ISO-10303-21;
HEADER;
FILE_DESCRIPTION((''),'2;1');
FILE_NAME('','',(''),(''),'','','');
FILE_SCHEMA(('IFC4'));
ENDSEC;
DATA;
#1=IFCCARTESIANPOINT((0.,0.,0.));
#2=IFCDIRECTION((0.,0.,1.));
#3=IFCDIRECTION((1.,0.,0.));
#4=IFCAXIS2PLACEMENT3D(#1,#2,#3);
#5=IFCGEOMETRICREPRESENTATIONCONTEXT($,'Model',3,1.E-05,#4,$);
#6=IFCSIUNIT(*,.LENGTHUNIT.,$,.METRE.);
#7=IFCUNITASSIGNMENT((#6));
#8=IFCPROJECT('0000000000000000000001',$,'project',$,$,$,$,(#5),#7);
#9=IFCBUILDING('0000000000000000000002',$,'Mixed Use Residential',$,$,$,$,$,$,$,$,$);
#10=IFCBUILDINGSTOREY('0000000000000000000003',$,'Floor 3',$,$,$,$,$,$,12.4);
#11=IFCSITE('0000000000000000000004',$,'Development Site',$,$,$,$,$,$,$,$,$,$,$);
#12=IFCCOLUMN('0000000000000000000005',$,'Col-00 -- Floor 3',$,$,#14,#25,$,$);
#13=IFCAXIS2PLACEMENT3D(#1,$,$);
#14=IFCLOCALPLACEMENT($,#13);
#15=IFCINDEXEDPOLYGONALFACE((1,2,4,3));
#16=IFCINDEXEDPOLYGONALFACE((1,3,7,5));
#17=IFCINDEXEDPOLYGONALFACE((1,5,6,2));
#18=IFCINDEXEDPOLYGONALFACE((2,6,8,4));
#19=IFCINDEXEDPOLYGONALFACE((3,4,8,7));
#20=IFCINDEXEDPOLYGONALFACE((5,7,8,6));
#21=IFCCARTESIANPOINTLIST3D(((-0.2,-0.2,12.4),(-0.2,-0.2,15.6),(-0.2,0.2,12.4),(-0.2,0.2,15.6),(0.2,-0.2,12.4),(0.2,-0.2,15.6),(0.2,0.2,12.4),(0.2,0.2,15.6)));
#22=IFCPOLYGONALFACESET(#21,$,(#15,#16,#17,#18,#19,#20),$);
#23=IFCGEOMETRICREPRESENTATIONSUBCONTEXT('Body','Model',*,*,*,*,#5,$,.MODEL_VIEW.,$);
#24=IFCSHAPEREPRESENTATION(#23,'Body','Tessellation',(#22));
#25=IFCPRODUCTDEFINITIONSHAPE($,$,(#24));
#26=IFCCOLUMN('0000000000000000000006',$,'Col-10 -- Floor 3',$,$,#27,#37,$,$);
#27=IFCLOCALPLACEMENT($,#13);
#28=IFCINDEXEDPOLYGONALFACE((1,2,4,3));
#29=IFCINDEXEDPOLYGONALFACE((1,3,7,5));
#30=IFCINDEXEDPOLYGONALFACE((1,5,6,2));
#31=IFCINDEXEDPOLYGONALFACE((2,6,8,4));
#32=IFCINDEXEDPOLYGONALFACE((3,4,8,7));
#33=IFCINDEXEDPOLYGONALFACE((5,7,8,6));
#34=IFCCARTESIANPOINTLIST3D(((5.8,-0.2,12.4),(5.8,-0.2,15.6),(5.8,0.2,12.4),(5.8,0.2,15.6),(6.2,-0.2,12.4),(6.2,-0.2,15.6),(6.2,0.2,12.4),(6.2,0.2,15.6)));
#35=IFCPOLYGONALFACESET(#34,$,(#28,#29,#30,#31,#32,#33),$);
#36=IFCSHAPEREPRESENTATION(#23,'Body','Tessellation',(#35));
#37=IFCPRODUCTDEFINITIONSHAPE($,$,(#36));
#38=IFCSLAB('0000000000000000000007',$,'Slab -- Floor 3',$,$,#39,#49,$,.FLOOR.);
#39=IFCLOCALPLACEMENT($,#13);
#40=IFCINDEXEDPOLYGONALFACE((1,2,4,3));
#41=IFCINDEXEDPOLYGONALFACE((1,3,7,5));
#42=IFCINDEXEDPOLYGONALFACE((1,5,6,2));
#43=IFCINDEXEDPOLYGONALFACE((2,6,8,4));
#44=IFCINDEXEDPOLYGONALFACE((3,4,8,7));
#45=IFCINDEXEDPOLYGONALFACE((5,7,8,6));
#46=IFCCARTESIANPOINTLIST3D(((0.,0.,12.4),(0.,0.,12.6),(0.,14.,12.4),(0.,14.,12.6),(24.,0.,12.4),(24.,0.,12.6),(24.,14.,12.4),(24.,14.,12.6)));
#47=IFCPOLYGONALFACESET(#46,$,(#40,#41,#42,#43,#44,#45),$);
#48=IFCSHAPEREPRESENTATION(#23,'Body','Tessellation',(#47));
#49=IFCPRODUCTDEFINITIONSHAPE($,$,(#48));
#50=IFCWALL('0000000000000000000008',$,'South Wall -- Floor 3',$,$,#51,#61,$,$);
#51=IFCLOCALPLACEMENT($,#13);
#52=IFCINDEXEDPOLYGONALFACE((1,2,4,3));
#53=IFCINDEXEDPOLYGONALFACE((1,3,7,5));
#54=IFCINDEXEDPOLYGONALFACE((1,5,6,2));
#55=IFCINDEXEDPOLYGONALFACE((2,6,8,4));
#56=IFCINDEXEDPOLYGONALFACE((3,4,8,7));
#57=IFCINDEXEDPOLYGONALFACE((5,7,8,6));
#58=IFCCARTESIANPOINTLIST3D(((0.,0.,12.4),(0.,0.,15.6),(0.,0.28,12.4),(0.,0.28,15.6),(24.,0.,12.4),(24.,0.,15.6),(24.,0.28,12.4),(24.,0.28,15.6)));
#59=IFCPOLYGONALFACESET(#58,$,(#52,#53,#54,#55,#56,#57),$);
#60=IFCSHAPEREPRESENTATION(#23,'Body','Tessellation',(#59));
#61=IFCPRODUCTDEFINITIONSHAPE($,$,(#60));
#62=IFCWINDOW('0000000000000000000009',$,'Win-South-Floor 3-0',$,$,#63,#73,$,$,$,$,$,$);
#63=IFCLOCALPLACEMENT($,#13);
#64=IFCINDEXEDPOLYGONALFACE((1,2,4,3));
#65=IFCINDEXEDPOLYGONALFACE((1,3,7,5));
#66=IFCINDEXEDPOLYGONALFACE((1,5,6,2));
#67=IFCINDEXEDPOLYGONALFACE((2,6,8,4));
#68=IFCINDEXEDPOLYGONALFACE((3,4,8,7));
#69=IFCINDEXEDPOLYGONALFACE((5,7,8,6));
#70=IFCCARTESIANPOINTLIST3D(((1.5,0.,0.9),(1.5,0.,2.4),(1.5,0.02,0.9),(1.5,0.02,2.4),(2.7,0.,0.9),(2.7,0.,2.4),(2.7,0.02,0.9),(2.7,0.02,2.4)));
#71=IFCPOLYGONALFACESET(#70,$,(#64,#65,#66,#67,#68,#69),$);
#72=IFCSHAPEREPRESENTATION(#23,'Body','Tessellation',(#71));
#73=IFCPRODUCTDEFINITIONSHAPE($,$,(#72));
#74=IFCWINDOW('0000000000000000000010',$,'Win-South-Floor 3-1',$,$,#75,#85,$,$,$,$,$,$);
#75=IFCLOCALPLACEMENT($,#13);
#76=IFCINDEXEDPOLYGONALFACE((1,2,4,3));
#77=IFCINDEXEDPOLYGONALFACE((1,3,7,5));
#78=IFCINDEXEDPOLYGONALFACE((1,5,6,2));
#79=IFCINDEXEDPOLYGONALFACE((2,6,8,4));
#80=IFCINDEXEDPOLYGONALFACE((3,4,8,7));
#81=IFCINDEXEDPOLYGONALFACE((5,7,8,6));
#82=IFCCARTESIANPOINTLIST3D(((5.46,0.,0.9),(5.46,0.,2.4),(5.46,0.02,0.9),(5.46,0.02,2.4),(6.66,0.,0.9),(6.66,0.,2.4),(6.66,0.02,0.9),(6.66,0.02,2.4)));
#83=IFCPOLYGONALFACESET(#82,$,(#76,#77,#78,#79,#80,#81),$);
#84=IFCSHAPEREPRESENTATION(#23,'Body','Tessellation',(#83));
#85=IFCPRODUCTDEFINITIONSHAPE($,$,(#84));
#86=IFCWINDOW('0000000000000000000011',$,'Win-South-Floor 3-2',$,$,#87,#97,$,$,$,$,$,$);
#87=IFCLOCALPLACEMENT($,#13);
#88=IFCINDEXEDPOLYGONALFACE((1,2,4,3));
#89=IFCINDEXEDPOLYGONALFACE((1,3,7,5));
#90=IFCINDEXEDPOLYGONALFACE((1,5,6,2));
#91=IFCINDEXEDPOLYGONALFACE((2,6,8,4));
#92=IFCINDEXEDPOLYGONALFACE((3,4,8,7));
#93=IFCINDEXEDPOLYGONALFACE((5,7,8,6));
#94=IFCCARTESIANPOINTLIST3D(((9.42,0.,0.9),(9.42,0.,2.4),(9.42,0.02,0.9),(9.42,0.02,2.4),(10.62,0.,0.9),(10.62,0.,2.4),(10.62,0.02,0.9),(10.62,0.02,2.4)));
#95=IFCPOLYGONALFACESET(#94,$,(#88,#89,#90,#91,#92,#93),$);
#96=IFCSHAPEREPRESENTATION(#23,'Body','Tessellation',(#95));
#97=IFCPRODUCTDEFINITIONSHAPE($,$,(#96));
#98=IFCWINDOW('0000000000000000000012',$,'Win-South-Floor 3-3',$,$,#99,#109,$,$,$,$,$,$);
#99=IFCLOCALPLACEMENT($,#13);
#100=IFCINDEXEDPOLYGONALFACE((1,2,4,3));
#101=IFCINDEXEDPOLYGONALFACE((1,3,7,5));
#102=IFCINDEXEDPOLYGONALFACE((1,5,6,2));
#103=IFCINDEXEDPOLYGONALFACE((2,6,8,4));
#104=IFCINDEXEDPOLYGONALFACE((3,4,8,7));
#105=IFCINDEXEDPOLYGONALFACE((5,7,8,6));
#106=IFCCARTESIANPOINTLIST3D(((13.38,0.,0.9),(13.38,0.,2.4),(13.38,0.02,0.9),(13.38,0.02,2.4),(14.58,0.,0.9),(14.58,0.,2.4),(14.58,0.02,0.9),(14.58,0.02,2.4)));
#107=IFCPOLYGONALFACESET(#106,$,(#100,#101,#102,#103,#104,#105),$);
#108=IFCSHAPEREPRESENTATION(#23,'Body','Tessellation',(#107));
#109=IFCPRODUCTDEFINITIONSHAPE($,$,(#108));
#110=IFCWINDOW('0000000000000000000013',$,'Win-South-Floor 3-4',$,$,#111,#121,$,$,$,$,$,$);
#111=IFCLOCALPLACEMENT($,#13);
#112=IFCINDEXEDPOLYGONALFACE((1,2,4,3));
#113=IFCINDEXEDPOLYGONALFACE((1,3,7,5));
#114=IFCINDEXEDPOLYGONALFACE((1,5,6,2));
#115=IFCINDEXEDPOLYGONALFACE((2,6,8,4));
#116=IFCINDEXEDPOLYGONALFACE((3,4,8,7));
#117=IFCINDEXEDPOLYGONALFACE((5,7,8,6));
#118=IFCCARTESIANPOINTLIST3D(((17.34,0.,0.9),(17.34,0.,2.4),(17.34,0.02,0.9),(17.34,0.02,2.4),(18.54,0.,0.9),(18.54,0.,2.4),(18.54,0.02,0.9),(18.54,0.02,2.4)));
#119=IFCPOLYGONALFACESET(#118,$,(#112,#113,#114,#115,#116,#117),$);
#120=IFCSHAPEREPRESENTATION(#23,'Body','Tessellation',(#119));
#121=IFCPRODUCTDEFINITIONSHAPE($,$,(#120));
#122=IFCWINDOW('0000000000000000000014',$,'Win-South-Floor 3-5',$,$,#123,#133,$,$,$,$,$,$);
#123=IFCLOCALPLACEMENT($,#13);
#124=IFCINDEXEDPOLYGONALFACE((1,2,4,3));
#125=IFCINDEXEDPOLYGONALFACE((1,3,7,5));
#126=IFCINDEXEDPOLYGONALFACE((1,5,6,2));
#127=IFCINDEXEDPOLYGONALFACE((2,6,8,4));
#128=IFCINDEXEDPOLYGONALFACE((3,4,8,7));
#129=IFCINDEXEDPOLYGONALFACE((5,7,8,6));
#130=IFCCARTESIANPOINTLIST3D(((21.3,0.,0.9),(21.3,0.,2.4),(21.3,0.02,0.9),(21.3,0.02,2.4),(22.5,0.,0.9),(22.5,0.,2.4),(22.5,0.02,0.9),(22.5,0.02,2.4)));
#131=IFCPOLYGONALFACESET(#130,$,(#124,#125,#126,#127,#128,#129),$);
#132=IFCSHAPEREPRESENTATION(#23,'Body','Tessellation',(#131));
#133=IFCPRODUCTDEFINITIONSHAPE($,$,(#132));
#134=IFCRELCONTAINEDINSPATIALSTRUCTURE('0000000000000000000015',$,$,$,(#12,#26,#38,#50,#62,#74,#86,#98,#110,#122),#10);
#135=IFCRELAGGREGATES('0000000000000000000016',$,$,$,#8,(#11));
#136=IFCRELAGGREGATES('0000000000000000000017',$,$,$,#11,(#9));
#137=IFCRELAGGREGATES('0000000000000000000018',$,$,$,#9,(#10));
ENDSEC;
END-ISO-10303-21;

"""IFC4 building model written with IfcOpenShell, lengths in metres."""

from ifc_helpers import new_model, si_unit, frame, origin_with_axes, place, context, subcontext, project, spatial, indexed_curve, rectangle, outline, extrude, element, fill, save


model = new_model("IFC4")

# Units and contexts
model_context = context("Model", 3, precision=1e-05, world=origin_with_axes())
body_context = subcontext(model_context, "Body", "Model", "MODEL_VIEW")
ifc_project = project(units=[si_unit("LENGTHUNIT", "METRE")], contexts=[model_context])

# Site, building, storey
site = spatial("IfcSite", under=ifc_project, Name="Development Site")
building = spatial("IfcBuilding", under=site, Name="Mixed Use Residential")
storey = spatial("IfcBuildingStorey", under=building, Name="Floor 3", Elevation=12.4)

# Columns
for number, where, z_axis, x_axis, name in (
    (1, (0.0, 0.0, 12.4), (0.0, 0.0, 1.0), (1.0, 0.0, 0.0), "Col-00 -- Floor 3"),
    (2, (6.0, 0.0, 12.4), (0.0, 0.0, 1.0), (1.0, 0.0, 0.0), "Col-10 -- Floor 3"),
):
    element("IfcColumn", number, at=place(None, frame(where, z_axis=z_axis, x_axis=x_axis)), inside=storey, Name=name, context=body_context, shape_type="SweptSolid", body=[
        extrude(rectangle(XDim=0.4, YDim=0.4), origin_with_axes(), (0.0, 0.0, 1.0), 3.2),
    ])

# Slab
slab_placement = place(None, frame((0.0, 0.0, 12.4), z_axis=(0.0, 0.0, 1.0), x_axis=(1.0, 0.0, 0.0)))
element("IfcSlab", 3, at=slab_placement, inside=storey, Name="Slab -- Floor 3", PredefinedType="FLOOR", context=body_context, shape_type="SweptSolid", body=[
    extrude(outline(indexed_curve([(0.0, 0.0), (24.0, 0.0), (24.0, 14.0), (0.0, 14.0), (0.0, 0.0)])), None, (0.0, 0.0, 1.0), 0.2),
])

# Wall, openings, windows
wall_1_placement = place(None, frame((0.0, 0.0, 12.4), z_axis=(0.0, 0.0, 1.0), x_axis=(1.0, 0.0, 0.0)))
wall_1 = element("IfcWall", 4, at=wall_1_placement, inside=storey, Name="South Wall -- Floor 3", context=body_context, shape_type="SweptSolid", body=[
    extrude(outline(indexed_curve([(0.0, 0.0), (0.0, 0.28), (24.0, 0.28), (24.0, 0.0), (0.0, 0.0)], self_intersect=False)), origin_with_axes(), (0.0, 0.0, 1.0), 3.2),
])
opening_1_placement = place(wall_1_placement, frame((1.5, 0.0, -11.5), z_axis=(0.0, 0.0, 1.0), x_axis=(1.0, 0.0, 0.0)))
opening_1 = element("IfcOpeningElement", 5, at=opening_1_placement, cuts=wall_1, context=body_context, shape_type="SweptSolid", body=[
    extrude(outline(indexed_curve([(0.0, 0.0), (0.0, 0.28), (1.2, 0.28), (1.2, 0.0), (0.0, 0.0)], self_intersect=False)), origin_with_axes(), (0.0, 0.0, 1.0), 1.5),
])
opening_2_placement = place(wall_1_placement, frame((5.46, 0.0, -11.5), z_axis=(0.0, 0.0, 1.0), x_axis=(1.0, 0.0, 0.0)))
opening_2 = element("IfcOpeningElement", 6, at=opening_2_placement, cuts=wall_1, context=body_context, shape_type="SweptSolid", body=[
    extrude(outline(indexed_curve([(0.0, 0.0), (0.0, 0.28), (1.2, 0.28), (1.2, 0.0), (0.0, 0.0)], self_intersect=False)), origin_with_axes(), (0.0, 0.0, 1.0), 1.5),
])
opening_3_placement = place(wall_1_placement, frame((9.42, 0.0, -11.5), z_axis=(0.0, 0.0, 1.0), x_axis=(1.0, 0.0, 0.0)))
opening_3 = element("IfcOpeningElement", 7, at=opening_3_placement, cuts=wall_1, context=body_context, shape_type="SweptSolid", body=[
    extrude(outline(indexed_curve([(0.0, 0.0), (0.0, 0.28), (1.2, 0.28), (1.2, 0.0), (0.0, 0.0)], self_intersect=False)), origin_with_axes(), (0.0, 0.0, 1.0), 1.5),
])
opening_4_placement = place(wall_1_placement, frame((13.38, 0.0, -11.5), z_axis=(0.0, 0.0, 1.0), x_axis=(1.0, 0.0, 0.0)))
opening_4 = element("IfcOpeningElement", 8, at=opening_4_placement, cuts=wall_1, context=body_context, shape_type="SweptSolid", body=[
    extrude(outline(indexed_curve([(0.0, 0.0), (0.0, 0.28), (1.2, 0.28), (1.2, 0.0), (0.0, 0.0)], self_intersect=False)), origin_with_axes(), (0.0, 0.0, 1.0), 1.5),
])
opening_5_placement = place(wall_1_placement, frame((17.34, 0.0, -11.5), z_axis=(0.0, 0.0, 1.0), x_axis=(1.0, 0.0, 0.0)))
opening_5 = element("IfcOpeningElement", 9, at=opening_5_placement, cuts=wall_1, context=body_context, shape_type="SweptSolid", body=[
    extrude(outline(indexed_curve([(0.0, 0.0), (0.0, 0.28), (1.2, 0.28), (1.2, 0.0), (0.0, 0.0)], self_intersect=False)), origin_with_axes(), (0.0, 0.0, 1.0), 1.5),
])
opening_6_placement = place(wall_1_placement, frame((21.3, 0.0, -11.5), z_axis=(0.0, 0.0, 1.0), x_axis=(1.0, 0.0, 0.0)))
opening_6 = element("IfcOpeningElement", 10, at=opening_6_placement, cuts=wall_1, context=body_context, shape_type="SweptSolid", body=[
    extrude(outline(indexed_curve([(0.0, 0.0), (0.0, 0.28), (1.2, 0.28), (1.2, 0.0), (0.0, 0.0)], self_intersect=False)), origin_with_axes(), (0.0, 0.0, 1.0), 1.5),
])
window_1_placement = place(None, frame((1.5, 0.0, 0.9), z_axis=(0.0, 0.0, 1.0), x_axis=(1.0, 0.0, 0.0)))
window_1 = element("IfcWindow", 11, at=window_1_placement, inside=storey, Name="Win-South-Floor 3-0", context=body_context, shape_type="SweptSolid", body=[
    extrude(outline(indexed_curve([(0.0, 0.0), (0.0, 0.02), (1.2, 0.02), (1.2, 0.0), (0.0, 0.0)], self_intersect=False)), origin_with_axes(), (0.0, 0.0, 1.0), 1.5),
])
fill(opening_1, window_1)
window_2_placement = place(None, frame((5.46, 0.0, 0.9), z_axis=(0.0, 0.0, 1.0), x_axis=(1.0, 0.0, 0.0)))
window_2 = element("IfcWindow", 12, at=window_2_placement, inside=storey, Name="Win-South-Floor 3-1", context=body_context, shape_type="SweptSolid", body=[
    extrude(outline(indexed_curve([(0.0, 0.0), (0.0, 0.02), (1.2, 0.02), (1.2, 0.0), (0.0, 0.0)], self_intersect=False)), origin_with_axes(), (0.0, 0.0, 1.0), 1.5),
])
fill(opening_2, window_2)
window_3_placement = place(None, frame((9.42, 0.0, 0.9), z_axis=(0.0, 0.0, 1.0), x_axis=(1.0, 0.0, 0.0)))
window_3 = element("IfcWindow", 13, at=window_3_placement, inside=storey, Name="Win-South-Floor 3-2", context=body_context, shape_type="SweptSolid", body=[
    extrude(outline(indexed_curve([(0.0, 0.0), (0.0, 0.02), (1.2, 0.02), (1.2, 0.0), (0.0, 0.0)], self_intersect=False)), origin_with_axes(), (0.0, 0.0, 1.0), 1.5),
])
fill(opening_3, window_3)
window_4_placement = place(None, frame((13.38, 0.0, 0.9), z_axis=(0.0, 0.0, 1.0), x_axis=(1.0, 0.0, 0.0)))
window_4 = element("IfcWindow", 14, at=window_4_placement, inside=storey, Name="Win-South-Floor 3-3", context=body_context, shape_type="SweptSolid", body=[
    extrude(outline(indexed_curve([(0.0, 0.0), (0.0, 0.02), (1.2, 0.02), (1.2, 0.0), (0.0, 0.0)], self_intersect=False)), origin_with_axes(), (0.0, 0.0, 1.0), 1.5),
])
fill(opening_4, window_4)
window_5_placement = place(None, frame((17.34, 0.0, 0.9), z_axis=(0.0, 0.0, 1.0), x_axis=(1.0, 0.0, 0.0)))
window_5 = element("IfcWindow", 15, at=window_5_placement, inside=storey, Name="Win-South-Floor 3-4", context=body_context, shape_type="SweptSolid", body=[
    extrude(outline(indexed_curve([(0.0, 0.0), (0.0, 0.02), (1.2, 0.02), (1.2, 0.0), (0.0, 0.0)], self_intersect=False)), origin_with_axes(), (0.0, 0.0, 1.0), 1.5),
])
fill(opening_5, window_5)
window_6_placement = place(None, frame((21.3, 0.0, 0.9), z_axis=(0.0, 0.0, 1.0), x_axis=(1.0, 0.0, 0.0)))
window_6 = element("IfcWindow", 16, at=window_6_placement, inside=storey, Name="Win-South-Floor 3-5", context=body_context, shape_type="SweptSolid", body=[
    extrude(outline(indexed_curve([(0.0, 0.0), (0.0, 0.02), (1.2, 0.02), (1.2, 0.0), (0.0, 0.0)], self_intersect=False)), origin_with_axes(), (0.0, 0.0, 1.0), 1.5),
])
fill(opening_6, window_6)

save(model, "model.ifc")
